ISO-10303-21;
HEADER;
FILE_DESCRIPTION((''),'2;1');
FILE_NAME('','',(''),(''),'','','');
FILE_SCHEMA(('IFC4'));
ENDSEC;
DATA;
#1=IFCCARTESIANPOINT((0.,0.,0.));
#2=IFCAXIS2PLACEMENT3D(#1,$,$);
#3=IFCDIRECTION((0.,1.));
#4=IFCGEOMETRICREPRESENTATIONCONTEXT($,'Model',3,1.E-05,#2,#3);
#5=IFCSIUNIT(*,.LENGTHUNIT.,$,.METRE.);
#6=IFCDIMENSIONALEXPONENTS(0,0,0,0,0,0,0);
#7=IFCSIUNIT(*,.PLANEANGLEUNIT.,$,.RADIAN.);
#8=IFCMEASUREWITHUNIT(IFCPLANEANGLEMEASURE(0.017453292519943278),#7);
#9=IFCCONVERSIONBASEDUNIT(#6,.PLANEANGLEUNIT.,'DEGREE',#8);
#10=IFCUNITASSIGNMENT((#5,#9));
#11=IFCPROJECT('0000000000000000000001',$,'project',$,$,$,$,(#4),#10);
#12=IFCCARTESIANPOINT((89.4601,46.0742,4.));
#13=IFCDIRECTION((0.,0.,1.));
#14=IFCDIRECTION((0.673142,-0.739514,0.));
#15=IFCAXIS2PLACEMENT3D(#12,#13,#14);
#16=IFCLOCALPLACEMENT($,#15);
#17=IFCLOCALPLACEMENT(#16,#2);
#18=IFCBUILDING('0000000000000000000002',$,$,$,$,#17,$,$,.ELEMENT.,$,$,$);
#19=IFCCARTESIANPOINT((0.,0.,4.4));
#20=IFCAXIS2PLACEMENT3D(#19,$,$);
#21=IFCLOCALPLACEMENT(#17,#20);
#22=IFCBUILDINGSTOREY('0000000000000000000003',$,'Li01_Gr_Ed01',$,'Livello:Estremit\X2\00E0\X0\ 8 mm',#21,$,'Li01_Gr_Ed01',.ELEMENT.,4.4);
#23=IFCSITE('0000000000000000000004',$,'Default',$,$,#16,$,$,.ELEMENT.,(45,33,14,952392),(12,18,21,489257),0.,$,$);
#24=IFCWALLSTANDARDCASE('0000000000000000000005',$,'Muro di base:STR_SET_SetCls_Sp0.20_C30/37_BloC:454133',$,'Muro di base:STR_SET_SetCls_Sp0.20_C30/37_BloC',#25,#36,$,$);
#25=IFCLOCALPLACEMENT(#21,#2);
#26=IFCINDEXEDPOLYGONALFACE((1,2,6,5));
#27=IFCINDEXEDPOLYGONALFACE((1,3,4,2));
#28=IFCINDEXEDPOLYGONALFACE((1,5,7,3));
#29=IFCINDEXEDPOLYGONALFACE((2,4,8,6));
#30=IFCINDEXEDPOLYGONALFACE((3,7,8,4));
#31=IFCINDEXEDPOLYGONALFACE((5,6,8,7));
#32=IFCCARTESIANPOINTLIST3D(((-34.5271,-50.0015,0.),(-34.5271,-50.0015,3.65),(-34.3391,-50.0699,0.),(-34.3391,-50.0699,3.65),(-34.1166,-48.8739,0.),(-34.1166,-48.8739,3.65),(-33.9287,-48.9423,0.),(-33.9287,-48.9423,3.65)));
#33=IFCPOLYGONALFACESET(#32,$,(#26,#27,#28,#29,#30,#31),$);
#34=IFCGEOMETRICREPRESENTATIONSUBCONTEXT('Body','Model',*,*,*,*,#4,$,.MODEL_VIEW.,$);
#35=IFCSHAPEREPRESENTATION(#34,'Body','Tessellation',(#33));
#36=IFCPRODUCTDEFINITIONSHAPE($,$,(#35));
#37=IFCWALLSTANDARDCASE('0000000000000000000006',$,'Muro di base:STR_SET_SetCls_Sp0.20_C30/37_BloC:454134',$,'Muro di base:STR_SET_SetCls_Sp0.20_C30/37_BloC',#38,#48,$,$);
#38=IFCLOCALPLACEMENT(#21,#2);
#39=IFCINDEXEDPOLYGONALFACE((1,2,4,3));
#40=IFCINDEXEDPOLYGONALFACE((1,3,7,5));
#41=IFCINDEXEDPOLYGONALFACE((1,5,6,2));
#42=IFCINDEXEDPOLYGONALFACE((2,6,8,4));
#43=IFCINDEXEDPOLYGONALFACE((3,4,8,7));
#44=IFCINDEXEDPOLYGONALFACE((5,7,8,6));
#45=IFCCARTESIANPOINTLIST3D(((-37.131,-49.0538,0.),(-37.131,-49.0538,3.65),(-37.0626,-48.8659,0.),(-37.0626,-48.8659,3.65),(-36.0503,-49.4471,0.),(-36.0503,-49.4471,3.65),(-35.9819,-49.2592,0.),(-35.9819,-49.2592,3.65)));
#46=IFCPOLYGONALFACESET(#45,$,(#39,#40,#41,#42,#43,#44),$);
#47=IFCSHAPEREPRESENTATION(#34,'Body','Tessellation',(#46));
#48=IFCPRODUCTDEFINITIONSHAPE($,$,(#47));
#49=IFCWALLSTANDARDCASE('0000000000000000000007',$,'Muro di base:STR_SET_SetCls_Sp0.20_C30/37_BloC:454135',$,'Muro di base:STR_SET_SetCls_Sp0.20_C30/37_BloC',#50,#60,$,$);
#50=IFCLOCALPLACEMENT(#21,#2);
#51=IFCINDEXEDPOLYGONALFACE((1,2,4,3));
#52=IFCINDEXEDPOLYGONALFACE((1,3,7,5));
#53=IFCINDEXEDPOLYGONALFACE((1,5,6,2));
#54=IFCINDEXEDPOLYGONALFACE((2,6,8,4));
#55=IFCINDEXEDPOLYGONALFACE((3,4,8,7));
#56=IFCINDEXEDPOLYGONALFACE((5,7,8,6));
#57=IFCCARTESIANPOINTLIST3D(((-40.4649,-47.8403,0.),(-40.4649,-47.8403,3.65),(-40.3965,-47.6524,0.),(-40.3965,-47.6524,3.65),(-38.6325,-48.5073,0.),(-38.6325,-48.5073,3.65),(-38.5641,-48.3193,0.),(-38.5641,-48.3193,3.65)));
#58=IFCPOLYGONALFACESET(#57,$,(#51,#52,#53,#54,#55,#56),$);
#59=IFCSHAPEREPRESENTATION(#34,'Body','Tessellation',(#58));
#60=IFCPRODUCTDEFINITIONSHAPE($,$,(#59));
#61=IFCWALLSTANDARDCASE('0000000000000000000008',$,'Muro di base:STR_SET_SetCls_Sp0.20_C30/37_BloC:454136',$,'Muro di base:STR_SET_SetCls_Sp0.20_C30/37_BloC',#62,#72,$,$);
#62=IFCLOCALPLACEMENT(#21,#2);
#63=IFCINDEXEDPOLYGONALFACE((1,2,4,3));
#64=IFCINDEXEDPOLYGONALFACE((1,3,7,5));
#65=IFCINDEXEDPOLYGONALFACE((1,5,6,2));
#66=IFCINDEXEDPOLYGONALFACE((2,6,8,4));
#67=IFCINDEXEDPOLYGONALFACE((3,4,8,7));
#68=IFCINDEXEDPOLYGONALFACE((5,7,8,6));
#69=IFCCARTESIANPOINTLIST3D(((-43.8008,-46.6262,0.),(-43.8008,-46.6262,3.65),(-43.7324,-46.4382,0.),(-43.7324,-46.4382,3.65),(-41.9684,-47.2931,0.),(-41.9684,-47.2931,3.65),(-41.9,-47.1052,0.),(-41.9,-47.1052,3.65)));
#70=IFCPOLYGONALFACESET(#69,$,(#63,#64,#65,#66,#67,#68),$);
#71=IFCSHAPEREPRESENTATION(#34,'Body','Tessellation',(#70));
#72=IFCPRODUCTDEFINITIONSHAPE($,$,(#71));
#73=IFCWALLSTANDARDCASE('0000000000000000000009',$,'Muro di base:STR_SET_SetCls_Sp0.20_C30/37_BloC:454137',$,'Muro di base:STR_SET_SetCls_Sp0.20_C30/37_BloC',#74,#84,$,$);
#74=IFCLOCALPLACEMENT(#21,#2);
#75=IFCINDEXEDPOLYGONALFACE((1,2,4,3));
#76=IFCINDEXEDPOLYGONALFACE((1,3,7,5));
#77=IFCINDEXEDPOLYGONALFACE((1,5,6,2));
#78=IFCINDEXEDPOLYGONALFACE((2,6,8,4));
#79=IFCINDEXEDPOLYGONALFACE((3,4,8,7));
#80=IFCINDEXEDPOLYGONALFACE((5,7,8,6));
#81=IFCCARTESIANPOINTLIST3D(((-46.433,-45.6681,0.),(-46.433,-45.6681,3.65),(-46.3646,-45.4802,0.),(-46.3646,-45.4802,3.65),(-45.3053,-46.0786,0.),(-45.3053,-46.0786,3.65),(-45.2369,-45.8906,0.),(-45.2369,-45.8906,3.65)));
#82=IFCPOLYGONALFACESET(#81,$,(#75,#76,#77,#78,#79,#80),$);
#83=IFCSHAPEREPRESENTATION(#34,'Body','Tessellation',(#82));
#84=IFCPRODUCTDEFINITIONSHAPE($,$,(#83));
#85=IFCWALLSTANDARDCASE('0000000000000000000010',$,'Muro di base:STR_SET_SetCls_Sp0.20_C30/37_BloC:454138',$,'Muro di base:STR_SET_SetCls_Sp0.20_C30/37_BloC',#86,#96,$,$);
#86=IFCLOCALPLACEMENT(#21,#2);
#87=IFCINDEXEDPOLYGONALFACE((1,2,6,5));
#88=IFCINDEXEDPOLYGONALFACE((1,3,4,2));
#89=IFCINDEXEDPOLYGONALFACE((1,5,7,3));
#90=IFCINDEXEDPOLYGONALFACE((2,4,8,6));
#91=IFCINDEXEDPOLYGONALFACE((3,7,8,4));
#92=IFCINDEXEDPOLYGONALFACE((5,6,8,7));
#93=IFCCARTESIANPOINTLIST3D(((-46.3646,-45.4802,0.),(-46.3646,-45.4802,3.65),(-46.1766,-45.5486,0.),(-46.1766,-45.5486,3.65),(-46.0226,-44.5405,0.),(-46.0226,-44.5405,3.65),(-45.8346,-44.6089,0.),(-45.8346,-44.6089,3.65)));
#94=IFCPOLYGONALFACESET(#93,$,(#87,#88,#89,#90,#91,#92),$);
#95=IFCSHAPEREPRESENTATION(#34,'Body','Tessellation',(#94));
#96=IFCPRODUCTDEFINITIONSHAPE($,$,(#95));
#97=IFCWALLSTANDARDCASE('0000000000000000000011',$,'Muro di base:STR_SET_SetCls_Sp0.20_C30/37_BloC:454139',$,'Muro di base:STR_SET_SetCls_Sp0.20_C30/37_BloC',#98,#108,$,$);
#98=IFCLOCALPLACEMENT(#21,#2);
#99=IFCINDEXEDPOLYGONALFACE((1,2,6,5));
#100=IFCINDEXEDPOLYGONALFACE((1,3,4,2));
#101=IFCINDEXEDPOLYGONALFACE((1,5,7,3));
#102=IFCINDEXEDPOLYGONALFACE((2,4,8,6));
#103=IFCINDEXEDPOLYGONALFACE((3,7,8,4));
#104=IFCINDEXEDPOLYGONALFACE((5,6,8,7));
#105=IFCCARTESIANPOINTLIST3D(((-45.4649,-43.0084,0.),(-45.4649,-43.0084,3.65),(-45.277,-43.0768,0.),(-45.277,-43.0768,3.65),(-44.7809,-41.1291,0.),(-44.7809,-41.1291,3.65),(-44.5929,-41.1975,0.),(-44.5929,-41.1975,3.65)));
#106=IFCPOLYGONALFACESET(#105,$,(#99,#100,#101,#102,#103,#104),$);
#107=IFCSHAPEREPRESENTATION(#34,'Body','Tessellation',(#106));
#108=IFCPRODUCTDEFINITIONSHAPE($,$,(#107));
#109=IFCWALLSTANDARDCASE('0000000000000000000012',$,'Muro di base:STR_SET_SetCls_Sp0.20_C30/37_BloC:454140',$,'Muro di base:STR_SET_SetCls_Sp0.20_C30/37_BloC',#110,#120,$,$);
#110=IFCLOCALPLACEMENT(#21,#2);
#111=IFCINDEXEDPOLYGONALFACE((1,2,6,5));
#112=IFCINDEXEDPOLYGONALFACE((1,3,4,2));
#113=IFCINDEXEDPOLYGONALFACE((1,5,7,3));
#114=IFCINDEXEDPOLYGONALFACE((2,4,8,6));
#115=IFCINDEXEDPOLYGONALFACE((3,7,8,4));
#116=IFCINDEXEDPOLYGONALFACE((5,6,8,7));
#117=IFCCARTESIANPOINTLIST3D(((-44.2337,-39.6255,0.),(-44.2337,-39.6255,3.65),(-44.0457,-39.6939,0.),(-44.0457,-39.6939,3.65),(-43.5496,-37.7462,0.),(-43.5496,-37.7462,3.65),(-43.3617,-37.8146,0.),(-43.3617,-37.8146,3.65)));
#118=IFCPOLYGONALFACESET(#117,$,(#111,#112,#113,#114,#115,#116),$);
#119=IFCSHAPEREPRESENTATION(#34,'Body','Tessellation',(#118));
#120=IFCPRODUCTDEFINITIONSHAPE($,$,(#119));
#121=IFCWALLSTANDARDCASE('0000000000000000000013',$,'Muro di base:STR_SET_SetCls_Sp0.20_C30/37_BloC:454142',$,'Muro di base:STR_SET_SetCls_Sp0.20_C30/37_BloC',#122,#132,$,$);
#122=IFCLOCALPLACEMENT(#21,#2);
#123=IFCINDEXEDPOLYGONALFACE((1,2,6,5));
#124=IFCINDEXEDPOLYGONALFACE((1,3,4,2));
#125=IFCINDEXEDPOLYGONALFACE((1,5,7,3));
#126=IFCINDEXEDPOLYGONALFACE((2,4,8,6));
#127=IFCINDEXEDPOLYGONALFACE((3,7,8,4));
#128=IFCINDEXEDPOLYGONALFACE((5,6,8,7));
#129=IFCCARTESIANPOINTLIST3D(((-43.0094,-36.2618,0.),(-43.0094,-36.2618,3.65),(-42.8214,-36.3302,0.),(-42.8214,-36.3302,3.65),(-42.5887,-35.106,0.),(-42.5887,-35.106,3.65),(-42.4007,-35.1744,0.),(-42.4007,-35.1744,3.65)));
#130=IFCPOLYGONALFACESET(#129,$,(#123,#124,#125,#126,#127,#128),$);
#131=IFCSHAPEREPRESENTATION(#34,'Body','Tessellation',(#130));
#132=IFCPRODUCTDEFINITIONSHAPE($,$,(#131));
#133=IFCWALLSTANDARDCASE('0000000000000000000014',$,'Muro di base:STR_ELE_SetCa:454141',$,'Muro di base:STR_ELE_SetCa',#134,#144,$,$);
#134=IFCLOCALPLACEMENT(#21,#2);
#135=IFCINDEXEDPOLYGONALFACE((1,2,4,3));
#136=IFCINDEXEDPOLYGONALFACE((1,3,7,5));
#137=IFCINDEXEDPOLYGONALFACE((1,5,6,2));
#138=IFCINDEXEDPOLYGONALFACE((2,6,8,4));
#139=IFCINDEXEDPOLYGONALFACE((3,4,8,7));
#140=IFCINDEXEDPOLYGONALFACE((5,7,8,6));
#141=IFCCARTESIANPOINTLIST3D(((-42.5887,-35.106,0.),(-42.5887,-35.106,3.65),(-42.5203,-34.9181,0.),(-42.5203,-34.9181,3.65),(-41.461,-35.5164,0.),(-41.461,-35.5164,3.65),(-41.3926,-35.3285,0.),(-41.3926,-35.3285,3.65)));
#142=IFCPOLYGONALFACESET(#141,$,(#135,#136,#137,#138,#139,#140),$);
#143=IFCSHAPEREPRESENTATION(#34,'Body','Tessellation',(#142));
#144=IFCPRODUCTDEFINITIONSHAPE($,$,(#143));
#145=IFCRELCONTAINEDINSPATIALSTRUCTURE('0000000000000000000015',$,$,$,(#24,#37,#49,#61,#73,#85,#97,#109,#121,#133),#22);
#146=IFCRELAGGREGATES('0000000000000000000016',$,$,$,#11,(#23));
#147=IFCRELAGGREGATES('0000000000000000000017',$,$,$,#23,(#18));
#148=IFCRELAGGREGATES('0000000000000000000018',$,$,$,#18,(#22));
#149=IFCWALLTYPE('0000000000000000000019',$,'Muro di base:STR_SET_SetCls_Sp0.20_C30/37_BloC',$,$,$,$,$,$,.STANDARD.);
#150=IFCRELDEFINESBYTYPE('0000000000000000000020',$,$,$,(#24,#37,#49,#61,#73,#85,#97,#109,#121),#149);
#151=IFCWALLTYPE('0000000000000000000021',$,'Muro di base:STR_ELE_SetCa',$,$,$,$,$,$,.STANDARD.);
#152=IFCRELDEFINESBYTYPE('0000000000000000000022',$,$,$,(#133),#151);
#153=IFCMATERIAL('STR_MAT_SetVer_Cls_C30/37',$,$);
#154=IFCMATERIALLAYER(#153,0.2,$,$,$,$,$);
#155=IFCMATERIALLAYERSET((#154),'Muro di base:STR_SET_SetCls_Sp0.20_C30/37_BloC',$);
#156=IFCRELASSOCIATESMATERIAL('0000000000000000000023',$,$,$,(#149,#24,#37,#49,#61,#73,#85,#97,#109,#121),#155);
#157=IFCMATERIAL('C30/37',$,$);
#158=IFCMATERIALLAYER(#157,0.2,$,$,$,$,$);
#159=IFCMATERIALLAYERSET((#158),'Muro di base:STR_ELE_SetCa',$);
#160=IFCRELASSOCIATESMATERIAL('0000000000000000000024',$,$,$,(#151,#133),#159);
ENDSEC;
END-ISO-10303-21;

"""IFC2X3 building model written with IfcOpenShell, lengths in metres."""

from ifc_helpers import new_model, entity, si_unit, converted_unit, direction, frame, frame_2d, origin, place, context, subcontext, project, spatial, rectangle, extrude, material, layer, layer_set, layer_usage, type_object, element, save


model = new_model("IFC2X3")

# Units and contexts
model_context = context("Model", 3, precision=1e-05, world=origin(), true_north=direction((0.0, 1.0)))
body_context = subcontext(model_context, "Body", "Model", "MODEL_VIEW")
ifc_project = project(units=[si_unit("LENGTHUNIT", "METRE"), converted_unit("PLANEANGLEUNIT", "DEGREE", entity("IfcPlaneAngleMeasure", 0.017453292519943278), si_unit("PLANEANGLEUNIT", "RADIAN"), dimensions=[0, 0, 0, 0, 0, 0, 0])], contexts=[model_context])

# Site, building, storey
site_placement = place(None, frame((89.4601, 46.0742, 4.0), z_axis=(0.0, 0.0, 1.0), x_axis=(0.673142, -0.739514, 0.0)))
site = spatial("IfcSite", under=ifc_project, at=site_placement, Name="Default", CompositionType="ELEMENT", RefLatitude=(45, 33, 14, 952392), RefLongitude=(12, 18, 21, 489257), RefElevation=0.0)
building_placement = place(site_placement, origin())
building = spatial("IfcBuilding", under=site, at=building_placement, CompositionType="ELEMENT")
storey_placement = place(building_placement, frame((0.0, 0.0, 4.4)))
storey = spatial("IfcBuildingStorey", under=building, at=storey_placement, Name="Li01_Gr_Ed01", ObjectType="Livello:Estremità 8 mm", LongName="Li01_Gr_Ed01", CompositionType="ELEMENT", Elevation=4.4)

# Walls
ifc_material_1 = material(Name="STR_MAT_SetVer_Cls_C30/37")
ifc_layer_1 = layer(ifc_material_1, 0.2)
ifc_layer_set_1 = layer_set([ifc_layer_1], Name="Muro di base:STR_SET_SetCls_Sp0.20_C30/37_BloC")
ifc_layer_usage_1 = layer_usage(ifc_layer_set_1, "AXIS2", "NEGATIVE", 0.1)
wall_type_1 = type_object("IfcWallType", Name="Muro di base:STR_SET_SetCls_Sp0.20_C30/37_BloC", PredefinedType="STANDARD", material=ifc_layer_set_1)
wall_1_placement = place(storey_placement, frame((-34.4331, -50.0357, 0.0), z_axis=(0.0, 0.0, 1.0), x_axis=(0.34202, 0.939693, 0.0)))
element("IfcWallStandardCase", 1, at=wall_1_placement, inside=storey, type_object=wall_type_1, material=ifc_layer_usage_1, Name="Muro di base:STR_SET_SetCls_Sp0.20_C30/37_BloC:454133", ObjectType="Muro di base:STR_SET_SetCls_Sp0.20_C30/37_BloC", context=body_context, shape_type="SweptSolid", body=[
    extrude(rectangle(XDim=1.2, YDim=0.2, at=frame_2d((0.6, 0.0), x_axis=(-1.0, 0.0))), origin(), (0.0, 0.0, 1.0), 3.65),
])
wall_2_placement = place(storey_placement, frame((-36.0161, -49.3531, 0.0), z_axis=(0.0, 0.0, 1.0), x_axis=(-0.939693, 0.34202, 0.0)))
element("IfcWallStandardCase", 2, at=wall_2_placement, inside=storey, type_object=wall_type_1, material=ifc_layer_usage_1, Name="Muro di base:STR_SET_SetCls_Sp0.20_C30/37_BloC:454134", ObjectType="Muro di base:STR_SET_SetCls_Sp0.20_C30/37_BloC", context=body_context, shape_type="SweptSolid", body=[
    extrude(rectangle(XDim=1.15, YDim=0.2, at=frame_2d((0.575, 0.0), x_axis=(-1.0, 0.0))), origin(), (0.0, 0.0, 1.0), 3.65),
])
wall_3_placement = place(storey_placement, frame((-38.5983, -48.4133, 0.0), z_axis=(0.0, 0.0, 1.0), x_axis=(-0.939693, 0.34202, 0.0)))
element("IfcWallStandardCase", 3, at=wall_3_placement, inside=storey, type_object=wall_type_1, material=ifc_layer_usage_1, Name="Muro di base:STR_SET_SetCls_Sp0.20_C30/37_BloC:454135", ObjectType="Muro di base:STR_SET_SetCls_Sp0.20_C30/37_BloC", context=body_context, shape_type="SweptSolid", body=[
    extrude(rectangle(XDim=1.95, YDim=0.2, at=frame_2d((0.975, 0.0), x_axis=(-1.0, 0.0))), origin(), (0.0, 0.0, 1.0), 3.65),
])
wall_4_placement = place(storey_placement, frame((-41.9342, -47.1991, 0.0), z_axis=(0.0, 0.0, 1.0), x_axis=(-0.939693, 0.34202, 0.0)))
element("IfcWallStandardCase", 4, at=wall_4_placement, inside=storey, type_object=wall_type_1, material=ifc_layer_usage_1, Name="Muro di base:STR_SET_SetCls_Sp0.20_C30/37_BloC:454136", ObjectType="Muro di base:STR_SET_SetCls_Sp0.20_C30/37_BloC", context=body_context, shape_type="SweptSolid", body=[
    extrude(rectangle(XDim=1.95, YDim=0.2, at=frame_2d((0.975, 0.0), x_axis=(-1.0, 0.0))), origin(), (0.0, 0.0, 1.0), 3.65),
])
wall_5_placement = place(storey_placement, frame((-45.2711, -45.9846, 0.0), z_axis=(0.0, 0.0, 1.0), x_axis=(-0.939693, 0.34202, 0.0)))
element("IfcWallStandardCase", 5, at=wall_5_placement, inside=storey, type_object=wall_type_1, material=ifc_layer_usage_1, Name="Muro di base:STR_SET_SetCls_Sp0.20_C30/37_BloC:454137", ObjectType="Muro di base:STR_SET_SetCls_Sp0.20_C30/37_BloC", context=body_context, shape_type="SweptSolid", body=[
    extrude(rectangle(XDim=1.2, YDim=0.2, at=frame_2d((0.6, 0.0), x_axis=(-1.0, 0.0))), origin(), (0.0, 0.0, 1.0), 3.65),
])
wall_6_placement = place(storey_placement, frame((-45.9286, -44.5747, 0.0), z_axis=(0.0, 0.0, 1.0), x_axis=(-0.34202, -0.939693, 0.0)))
element("IfcWallStandardCase", 6, at=wall_6_placement, inside=storey, type_object=wall_type_1, material=ifc_layer_usage_1, Name="Muro di base:STR_SET_SetCls_Sp0.20_C30/37_BloC:454138", ObjectType="Muro di base:STR_SET_SetCls_Sp0.20_C30/37_BloC", context=body_context, shape_type="SweptSolid", body=[
    extrude(rectangle(XDim=1.0, YDim=0.2, at=frame_2d((0.5, 0.0), x_axis=(-1.0, 0.0))), origin(), (0.0, 0.0, 1.0), 3.65),
])
wall_7_placement = place(storey_placement, frame((-45.371, -43.0426, 0.0), z_axis=(0.0, 0.0, 1.0), x_axis=(0.34202, 0.939693, 0.0)))
element("IfcWallStandardCase", 7, at=wall_7_placement, inside=storey, type_object=wall_type_1, material=ifc_layer_usage_1, Name="Muro di base:STR_SET_SetCls_Sp0.20_C30/37_BloC:454139", ObjectType="Muro di base:STR_SET_SetCls_Sp0.20_C30/37_BloC", context=body_context, shape_type="SweptSolid", body=[
    extrude(rectangle(XDim=2.0, YDim=0.2, at=frame_2d((1.0, 0.0), x_axis=(-1.0, 0.0))), origin(), (0.0, 0.0, 1.0), 3.65),
])
wall_8_placement = place(storey_placement, frame((-44.1397, -39.6597, 0.0), z_axis=(0.0, 0.0, 1.0), x_axis=(0.34202, 0.939693, 0.0)))
element("IfcWallStandardCase", 8, at=wall_8_placement, inside=storey, type_object=wall_type_1, material=ifc_layer_usage_1, Name="Muro di base:STR_SET_SetCls_Sp0.20_C30/37_BloC:454140", ObjectType="Muro di base:STR_SET_SetCls_Sp0.20_C30/37_BloC", context=body_context, shape_type="SweptSolid", body=[
    extrude(rectangle(XDim=2.0, YDim=0.2, at=frame_2d((1.0, 0.0), x_axis=(-1.0, 0.0))), origin(), (0.0, 0.0, 1.0), 3.65),
])
wall_9_placement = place(storey_placement, frame((-42.4947, -35.1402, 0.0), z_axis=(0.0, 0.0, 1.0), x_axis=(-0.34202, -0.939693, 0.0)))
element("IfcWallStandardCase", 9, at=wall_9_placement, inside=storey, type_object=wall_type_1, material=ifc_layer_usage_1, Name="Muro di base:STR_SET_SetCls_Sp0.20_C30/37_BloC:454142", ObjectType="Muro di base:STR_SET_SetCls_Sp0.20_C30/37_BloC", context=body_context, shape_type="SweptSolid", body=[
    extrude(rectangle(XDim=1.23, YDim=0.2, at=frame_2d((0.615, 0.0), x_axis=(-1.0, 0.0))), origin(), (0.0, 0.0, 1.0), 3.65),
])
ifc_material_2 = material(Name="C30/37")
ifc_layer_2 = layer(ifc_material_2, 0.2)
ifc_layer_set_2 = layer_set([ifc_layer_2], Name="Muro di base:STR_ELE_SetCa")
ifc_layer_usage_2 = layer_usage(ifc_layer_set_2, "AXIS2", "NEGATIVE", 0.1)
wall_type_2 = type_object("IfcWallType", Name="Muro di base:STR_ELE_SetCa", PredefinedType="STANDARD", material=ifc_layer_set_2)
wall_10_placement = place(storey_placement, frame((-41.4268, -35.4224, 0.0), z_axis=(0.0, 0.0, 1.0), x_axis=(-0.939693, 0.34202, 0.0)))
element("IfcWallStandardCase", 10, at=wall_10_placement, inside=storey, type_object=wall_type_2, material=ifc_layer_usage_2, Name="Muro di base:STR_ELE_SetCa:454141", ObjectType="Muro di base:STR_ELE_SetCa", context=body_context, shape_type="SweptSolid", body=[
    extrude(rectangle(XDim=1.2, YDim=0.2, at=frame_2d((0.6, 0.0), x_axis=(-1.0, 0.0))), origin(), (0.0, 0.0, 1.0), 3.65),
])

save(model, "model.ifc")
